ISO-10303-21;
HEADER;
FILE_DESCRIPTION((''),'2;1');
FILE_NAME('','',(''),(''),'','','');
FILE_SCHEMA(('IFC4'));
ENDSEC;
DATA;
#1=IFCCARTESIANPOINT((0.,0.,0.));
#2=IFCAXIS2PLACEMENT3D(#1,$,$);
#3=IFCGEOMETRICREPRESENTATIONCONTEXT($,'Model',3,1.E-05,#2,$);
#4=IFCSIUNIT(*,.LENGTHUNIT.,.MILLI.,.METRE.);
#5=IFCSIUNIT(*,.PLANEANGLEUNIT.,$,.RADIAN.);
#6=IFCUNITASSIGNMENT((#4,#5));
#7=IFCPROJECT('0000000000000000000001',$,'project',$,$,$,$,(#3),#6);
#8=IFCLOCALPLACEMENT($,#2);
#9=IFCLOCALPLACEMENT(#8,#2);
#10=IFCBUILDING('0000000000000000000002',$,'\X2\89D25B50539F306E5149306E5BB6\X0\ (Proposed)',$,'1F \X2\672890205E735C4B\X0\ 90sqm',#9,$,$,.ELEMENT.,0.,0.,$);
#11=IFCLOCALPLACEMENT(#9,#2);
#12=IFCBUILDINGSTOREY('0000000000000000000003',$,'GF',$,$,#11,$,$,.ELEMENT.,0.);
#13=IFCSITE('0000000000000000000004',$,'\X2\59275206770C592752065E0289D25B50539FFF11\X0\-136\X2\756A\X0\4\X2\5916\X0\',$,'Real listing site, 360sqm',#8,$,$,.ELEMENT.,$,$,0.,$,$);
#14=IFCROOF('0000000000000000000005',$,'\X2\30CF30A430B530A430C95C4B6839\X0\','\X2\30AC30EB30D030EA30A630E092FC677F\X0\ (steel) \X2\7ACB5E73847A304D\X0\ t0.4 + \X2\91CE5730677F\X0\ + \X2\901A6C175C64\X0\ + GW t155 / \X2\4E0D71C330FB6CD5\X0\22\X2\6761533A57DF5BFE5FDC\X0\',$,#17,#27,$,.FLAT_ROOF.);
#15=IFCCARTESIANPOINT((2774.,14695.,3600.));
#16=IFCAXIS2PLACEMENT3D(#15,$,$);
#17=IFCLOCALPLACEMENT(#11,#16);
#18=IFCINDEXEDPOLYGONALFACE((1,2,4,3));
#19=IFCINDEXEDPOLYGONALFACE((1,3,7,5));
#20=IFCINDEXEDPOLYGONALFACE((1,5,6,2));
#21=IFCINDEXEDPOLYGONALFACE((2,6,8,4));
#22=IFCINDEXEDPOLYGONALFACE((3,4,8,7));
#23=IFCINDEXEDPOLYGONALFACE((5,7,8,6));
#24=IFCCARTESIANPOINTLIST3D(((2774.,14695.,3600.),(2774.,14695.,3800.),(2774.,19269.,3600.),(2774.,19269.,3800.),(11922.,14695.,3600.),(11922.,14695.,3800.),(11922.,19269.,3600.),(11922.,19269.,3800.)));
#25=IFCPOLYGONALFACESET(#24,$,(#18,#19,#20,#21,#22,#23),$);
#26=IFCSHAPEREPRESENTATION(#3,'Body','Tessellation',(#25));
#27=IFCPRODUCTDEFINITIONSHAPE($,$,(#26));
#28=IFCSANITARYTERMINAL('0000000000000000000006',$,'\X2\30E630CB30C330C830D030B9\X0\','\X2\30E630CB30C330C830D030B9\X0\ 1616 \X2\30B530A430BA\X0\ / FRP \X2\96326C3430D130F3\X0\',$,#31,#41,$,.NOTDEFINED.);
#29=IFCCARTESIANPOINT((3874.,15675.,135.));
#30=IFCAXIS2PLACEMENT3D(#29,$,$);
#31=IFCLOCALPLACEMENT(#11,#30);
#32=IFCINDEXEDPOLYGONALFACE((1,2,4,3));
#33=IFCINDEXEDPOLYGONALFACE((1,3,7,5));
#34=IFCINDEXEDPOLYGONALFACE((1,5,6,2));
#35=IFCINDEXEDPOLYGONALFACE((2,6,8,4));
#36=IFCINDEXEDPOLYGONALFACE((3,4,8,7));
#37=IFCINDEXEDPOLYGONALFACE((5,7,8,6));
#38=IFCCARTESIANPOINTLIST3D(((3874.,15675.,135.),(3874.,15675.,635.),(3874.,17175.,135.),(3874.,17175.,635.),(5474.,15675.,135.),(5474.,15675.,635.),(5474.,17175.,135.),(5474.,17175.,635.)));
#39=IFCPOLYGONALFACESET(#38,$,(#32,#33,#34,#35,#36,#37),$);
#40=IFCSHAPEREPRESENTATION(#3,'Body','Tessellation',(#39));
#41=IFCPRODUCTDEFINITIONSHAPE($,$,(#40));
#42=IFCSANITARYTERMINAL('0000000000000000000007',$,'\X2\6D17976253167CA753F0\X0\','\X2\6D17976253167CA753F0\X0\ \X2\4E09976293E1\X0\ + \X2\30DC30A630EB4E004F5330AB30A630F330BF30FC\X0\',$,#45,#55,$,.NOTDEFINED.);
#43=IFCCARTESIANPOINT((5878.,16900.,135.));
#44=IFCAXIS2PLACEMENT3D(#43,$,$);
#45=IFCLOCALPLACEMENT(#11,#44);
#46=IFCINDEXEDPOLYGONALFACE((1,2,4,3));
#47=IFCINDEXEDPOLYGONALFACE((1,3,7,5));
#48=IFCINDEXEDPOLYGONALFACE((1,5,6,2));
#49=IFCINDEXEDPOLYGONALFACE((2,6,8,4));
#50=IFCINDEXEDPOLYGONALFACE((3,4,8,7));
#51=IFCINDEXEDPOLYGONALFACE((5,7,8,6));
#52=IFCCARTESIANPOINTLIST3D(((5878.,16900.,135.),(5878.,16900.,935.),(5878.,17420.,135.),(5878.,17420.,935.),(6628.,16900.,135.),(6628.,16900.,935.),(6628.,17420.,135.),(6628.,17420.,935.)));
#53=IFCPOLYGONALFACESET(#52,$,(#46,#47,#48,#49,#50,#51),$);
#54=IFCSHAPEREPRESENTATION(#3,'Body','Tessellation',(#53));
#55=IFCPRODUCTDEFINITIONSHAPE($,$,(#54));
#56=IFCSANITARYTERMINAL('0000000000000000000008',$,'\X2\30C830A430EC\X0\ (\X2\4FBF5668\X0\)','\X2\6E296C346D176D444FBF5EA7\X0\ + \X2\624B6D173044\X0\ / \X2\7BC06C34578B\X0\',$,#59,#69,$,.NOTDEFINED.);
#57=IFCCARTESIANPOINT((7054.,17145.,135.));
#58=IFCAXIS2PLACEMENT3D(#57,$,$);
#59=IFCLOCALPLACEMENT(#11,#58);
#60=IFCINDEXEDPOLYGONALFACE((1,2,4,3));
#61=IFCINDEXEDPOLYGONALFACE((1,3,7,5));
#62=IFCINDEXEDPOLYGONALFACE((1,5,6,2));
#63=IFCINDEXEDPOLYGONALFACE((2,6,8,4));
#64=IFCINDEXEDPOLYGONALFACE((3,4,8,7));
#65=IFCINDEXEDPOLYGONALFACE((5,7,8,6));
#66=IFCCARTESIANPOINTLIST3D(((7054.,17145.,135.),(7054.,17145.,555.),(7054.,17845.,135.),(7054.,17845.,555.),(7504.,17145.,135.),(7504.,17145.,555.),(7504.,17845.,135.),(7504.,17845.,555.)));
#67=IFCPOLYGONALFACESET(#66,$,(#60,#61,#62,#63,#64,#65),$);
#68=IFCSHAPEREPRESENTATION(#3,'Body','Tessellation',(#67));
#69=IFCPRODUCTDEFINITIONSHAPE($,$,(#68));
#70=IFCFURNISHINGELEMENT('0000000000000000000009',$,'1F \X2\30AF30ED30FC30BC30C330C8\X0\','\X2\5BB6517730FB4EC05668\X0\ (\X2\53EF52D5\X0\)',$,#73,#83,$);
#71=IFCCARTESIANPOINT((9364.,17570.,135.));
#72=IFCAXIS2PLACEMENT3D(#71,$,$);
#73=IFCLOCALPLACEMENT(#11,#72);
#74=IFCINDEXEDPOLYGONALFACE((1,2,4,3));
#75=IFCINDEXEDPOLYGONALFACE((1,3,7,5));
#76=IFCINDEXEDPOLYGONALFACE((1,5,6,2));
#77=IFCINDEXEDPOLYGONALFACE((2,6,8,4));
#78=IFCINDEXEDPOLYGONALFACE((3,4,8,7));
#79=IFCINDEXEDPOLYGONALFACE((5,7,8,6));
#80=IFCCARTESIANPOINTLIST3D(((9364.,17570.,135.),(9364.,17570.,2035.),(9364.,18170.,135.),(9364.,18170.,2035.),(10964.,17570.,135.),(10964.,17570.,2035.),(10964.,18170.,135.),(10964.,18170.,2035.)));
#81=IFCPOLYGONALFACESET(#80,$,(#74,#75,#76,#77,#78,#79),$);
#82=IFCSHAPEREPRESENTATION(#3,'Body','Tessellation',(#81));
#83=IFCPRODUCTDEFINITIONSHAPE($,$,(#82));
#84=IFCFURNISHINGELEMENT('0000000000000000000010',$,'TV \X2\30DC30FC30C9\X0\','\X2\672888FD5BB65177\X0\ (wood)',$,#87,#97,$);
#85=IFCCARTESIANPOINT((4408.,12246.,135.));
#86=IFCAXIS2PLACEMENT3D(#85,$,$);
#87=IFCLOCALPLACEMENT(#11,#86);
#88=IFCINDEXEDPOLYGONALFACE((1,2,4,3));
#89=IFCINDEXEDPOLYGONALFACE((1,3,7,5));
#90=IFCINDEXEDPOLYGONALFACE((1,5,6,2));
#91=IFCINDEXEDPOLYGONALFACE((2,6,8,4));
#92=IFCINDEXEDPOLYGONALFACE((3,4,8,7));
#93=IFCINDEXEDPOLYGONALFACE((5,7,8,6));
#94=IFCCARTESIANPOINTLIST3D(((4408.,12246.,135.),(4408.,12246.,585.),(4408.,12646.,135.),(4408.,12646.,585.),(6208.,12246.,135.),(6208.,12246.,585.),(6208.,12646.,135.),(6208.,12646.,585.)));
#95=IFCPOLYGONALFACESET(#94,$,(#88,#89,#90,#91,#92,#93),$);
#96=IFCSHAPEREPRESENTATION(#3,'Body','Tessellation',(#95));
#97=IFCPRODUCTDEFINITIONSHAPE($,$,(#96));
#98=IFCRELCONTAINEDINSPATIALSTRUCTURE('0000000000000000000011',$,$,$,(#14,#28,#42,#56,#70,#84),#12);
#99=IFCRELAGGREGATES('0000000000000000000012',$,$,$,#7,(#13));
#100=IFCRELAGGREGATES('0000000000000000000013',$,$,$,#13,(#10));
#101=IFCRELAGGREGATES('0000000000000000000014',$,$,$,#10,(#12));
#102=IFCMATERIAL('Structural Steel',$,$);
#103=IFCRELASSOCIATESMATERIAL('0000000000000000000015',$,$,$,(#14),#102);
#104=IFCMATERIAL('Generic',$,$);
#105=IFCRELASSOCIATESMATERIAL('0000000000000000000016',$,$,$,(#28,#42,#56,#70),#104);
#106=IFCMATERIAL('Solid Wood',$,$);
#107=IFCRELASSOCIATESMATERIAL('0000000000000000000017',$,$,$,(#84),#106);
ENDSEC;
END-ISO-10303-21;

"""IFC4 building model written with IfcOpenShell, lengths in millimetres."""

from ifc_helpers import new_model, si_unit, frame, frame_2d, origin, place, context, project, spatial, rectangle, extrude, material, element, save


model = new_model("IFC4")

# Units and contexts
model_context = context("Model", 3, precision=1e-05, world=origin())
ifc_project = project(units=[si_unit("LENGTHUNIT", "METRE", prefix="MILLI"), si_unit("PLANEANGLEUNIT", "RADIAN")], contexts=[model_context])

# Site, building, storey
site_placement = place(None, origin())
site = spatial("IfcSite", under=ifc_project, at=site_placement, Name="大分県大分市角子原１-136番4外", ObjectType="Real listing site, 360sqm", CompositionType="ELEMENT", RefElevation=0.0)
building_placement = place(site_placement, origin())
building = spatial("IfcBuilding", under=site, at=building_placement, Name="角子原の光の家 (Proposed)", ObjectType="1F 木造平屋 90sqm", CompositionType="ELEMENT", ElevationOfRefHeight=0.0, ElevationOfTerrain=0.0)
storey_placement = place(building_placement, origin())
storey = spatial("IfcBuildingStorey", under=building, at=storey_placement, Name="GF", CompositionType="ELEMENT", Elevation=0.0)

# Shared definitions
ifc_material_1 = material(Name="Solid Wood")

# Roof
ifc_material_2 = material(Name="Structural Steel")
roof_placement = place(storey_placement, frame((2774.0, 14695.0, 3600.0)))
element("IfcRoof", 1, at=roof_placement, inside=storey, material=ifc_material_2, Name="ハイサイド屋根", Description="ガルバリウム鋼板 (steel) 立平葺き t0.4 + 野地板 + 通気層 + GW t155 / 不燃・法22条区域対応", PredefinedType="FLAT_ROOF", context=model_context, shape_type="SweptSolid", body=[
    extrude(rectangle(XDim=9148.0, YDim=4574.0, at=frame_2d((4574.0, 2287.0))), frame((2774.0, 14695.0, 3600.0)), (0.0, 0.0, 1.0), 200.0),
])

# Sanitary terminals
ifc_material_3 = material(Name="Generic")
sanitary_terminal_1_placement = place(storey_placement, frame((3874.0, 15675.0, 135.0)))
element("IfcSanitaryTerminal", 2, at=sanitary_terminal_1_placement, inside=storey, material=ifc_material_3, Name="ユニットバス", Description="ユニットバス 1616 サイズ / FRP 防水パン", PredefinedType="NOTDEFINED", context=model_context, shape_type="SweptSolid", body=[
    extrude(rectangle(XDim=1600.0, YDim=1500.0, at=frame_2d((800.0, 750.0))), frame((3874.0, 15675.0, 135.0)), (0.0, 0.0, 1.0), 500.0),
])
sanitary_terminal_2_placement = place(storey_placement, frame((5878.0, 16900.0, 135.0)))
element("IfcSanitaryTerminal", 3, at=sanitary_terminal_2_placement, inside=storey, material=ifc_material_3, Name="洗面化粧台", Description="洗面化粧台 三面鏡 + ボウル一体カウンター", PredefinedType="NOTDEFINED", context=model_context, shape_type="SweptSolid", body=[
    extrude(rectangle(XDim=750.0, YDim=520.0, at=frame_2d((375.0, 260.0))), frame((5878.0, 16900.0, 135.0)), (0.0, 0.0, 1.0), 800.0),
])
sanitary_terminal_3_placement = place(storey_placement, frame((7054.0, 17145.0, 135.0)))
element("IfcSanitaryTerminal", 4, at=sanitary_terminal_3_placement, inside=storey, material=ifc_material_3, Name="トイレ (便器)", Description="温水洗浄便座 + 手洗い / 節水型", PredefinedType="NOTDEFINED", context=model_context, shape_type="SweptSolid", body=[
    extrude(rectangle(XDim=450.0, YDim=700.0, at=frame_2d((225.0, 350.0))), frame((7054.0, 17145.0, 135.0)), (0.0, 0.0, 1.0), 420.0),
])

# Furnishing elements
furnishing_1_placement = place(storey_placement, frame((9364.0, 17570.0, 135.0)))
element("IfcFurnishingElement", 5, at=furnishing_1_placement, inside=storey, material=ifc_material_3, Name="1F クローゼット", Description="家具・什器 (可動)", context=model_context, shape_type="SweptSolid", body=[
    extrude(rectangle(XDim=1600.0, YDim=600.0, at=frame_2d((800.0, 300.0))), frame((9364.0, 17570.0, 135.0)), (0.0, 0.0, 1.0), 1900.0),
])
furnishing_2_placement = place(storey_placement, frame((4408.0, 12246.0, 135.0)))
element("IfcFurnishingElement", 6, at=furnishing_2_placement, inside=storey, material=ifc_material_1, Name="TV ボード", Description="木製家具 (wood)", context=model_context, shape_type="SweptSolid", body=[
    extrude(rectangle(XDim=1800.0, YDim=400.0, at=frame_2d((900.0, 200.0))), frame((4408.0, 12246.0, 135.0)), (0.0, 0.0, 1.0), 450.0),
])

save(model, "model.ifc")
